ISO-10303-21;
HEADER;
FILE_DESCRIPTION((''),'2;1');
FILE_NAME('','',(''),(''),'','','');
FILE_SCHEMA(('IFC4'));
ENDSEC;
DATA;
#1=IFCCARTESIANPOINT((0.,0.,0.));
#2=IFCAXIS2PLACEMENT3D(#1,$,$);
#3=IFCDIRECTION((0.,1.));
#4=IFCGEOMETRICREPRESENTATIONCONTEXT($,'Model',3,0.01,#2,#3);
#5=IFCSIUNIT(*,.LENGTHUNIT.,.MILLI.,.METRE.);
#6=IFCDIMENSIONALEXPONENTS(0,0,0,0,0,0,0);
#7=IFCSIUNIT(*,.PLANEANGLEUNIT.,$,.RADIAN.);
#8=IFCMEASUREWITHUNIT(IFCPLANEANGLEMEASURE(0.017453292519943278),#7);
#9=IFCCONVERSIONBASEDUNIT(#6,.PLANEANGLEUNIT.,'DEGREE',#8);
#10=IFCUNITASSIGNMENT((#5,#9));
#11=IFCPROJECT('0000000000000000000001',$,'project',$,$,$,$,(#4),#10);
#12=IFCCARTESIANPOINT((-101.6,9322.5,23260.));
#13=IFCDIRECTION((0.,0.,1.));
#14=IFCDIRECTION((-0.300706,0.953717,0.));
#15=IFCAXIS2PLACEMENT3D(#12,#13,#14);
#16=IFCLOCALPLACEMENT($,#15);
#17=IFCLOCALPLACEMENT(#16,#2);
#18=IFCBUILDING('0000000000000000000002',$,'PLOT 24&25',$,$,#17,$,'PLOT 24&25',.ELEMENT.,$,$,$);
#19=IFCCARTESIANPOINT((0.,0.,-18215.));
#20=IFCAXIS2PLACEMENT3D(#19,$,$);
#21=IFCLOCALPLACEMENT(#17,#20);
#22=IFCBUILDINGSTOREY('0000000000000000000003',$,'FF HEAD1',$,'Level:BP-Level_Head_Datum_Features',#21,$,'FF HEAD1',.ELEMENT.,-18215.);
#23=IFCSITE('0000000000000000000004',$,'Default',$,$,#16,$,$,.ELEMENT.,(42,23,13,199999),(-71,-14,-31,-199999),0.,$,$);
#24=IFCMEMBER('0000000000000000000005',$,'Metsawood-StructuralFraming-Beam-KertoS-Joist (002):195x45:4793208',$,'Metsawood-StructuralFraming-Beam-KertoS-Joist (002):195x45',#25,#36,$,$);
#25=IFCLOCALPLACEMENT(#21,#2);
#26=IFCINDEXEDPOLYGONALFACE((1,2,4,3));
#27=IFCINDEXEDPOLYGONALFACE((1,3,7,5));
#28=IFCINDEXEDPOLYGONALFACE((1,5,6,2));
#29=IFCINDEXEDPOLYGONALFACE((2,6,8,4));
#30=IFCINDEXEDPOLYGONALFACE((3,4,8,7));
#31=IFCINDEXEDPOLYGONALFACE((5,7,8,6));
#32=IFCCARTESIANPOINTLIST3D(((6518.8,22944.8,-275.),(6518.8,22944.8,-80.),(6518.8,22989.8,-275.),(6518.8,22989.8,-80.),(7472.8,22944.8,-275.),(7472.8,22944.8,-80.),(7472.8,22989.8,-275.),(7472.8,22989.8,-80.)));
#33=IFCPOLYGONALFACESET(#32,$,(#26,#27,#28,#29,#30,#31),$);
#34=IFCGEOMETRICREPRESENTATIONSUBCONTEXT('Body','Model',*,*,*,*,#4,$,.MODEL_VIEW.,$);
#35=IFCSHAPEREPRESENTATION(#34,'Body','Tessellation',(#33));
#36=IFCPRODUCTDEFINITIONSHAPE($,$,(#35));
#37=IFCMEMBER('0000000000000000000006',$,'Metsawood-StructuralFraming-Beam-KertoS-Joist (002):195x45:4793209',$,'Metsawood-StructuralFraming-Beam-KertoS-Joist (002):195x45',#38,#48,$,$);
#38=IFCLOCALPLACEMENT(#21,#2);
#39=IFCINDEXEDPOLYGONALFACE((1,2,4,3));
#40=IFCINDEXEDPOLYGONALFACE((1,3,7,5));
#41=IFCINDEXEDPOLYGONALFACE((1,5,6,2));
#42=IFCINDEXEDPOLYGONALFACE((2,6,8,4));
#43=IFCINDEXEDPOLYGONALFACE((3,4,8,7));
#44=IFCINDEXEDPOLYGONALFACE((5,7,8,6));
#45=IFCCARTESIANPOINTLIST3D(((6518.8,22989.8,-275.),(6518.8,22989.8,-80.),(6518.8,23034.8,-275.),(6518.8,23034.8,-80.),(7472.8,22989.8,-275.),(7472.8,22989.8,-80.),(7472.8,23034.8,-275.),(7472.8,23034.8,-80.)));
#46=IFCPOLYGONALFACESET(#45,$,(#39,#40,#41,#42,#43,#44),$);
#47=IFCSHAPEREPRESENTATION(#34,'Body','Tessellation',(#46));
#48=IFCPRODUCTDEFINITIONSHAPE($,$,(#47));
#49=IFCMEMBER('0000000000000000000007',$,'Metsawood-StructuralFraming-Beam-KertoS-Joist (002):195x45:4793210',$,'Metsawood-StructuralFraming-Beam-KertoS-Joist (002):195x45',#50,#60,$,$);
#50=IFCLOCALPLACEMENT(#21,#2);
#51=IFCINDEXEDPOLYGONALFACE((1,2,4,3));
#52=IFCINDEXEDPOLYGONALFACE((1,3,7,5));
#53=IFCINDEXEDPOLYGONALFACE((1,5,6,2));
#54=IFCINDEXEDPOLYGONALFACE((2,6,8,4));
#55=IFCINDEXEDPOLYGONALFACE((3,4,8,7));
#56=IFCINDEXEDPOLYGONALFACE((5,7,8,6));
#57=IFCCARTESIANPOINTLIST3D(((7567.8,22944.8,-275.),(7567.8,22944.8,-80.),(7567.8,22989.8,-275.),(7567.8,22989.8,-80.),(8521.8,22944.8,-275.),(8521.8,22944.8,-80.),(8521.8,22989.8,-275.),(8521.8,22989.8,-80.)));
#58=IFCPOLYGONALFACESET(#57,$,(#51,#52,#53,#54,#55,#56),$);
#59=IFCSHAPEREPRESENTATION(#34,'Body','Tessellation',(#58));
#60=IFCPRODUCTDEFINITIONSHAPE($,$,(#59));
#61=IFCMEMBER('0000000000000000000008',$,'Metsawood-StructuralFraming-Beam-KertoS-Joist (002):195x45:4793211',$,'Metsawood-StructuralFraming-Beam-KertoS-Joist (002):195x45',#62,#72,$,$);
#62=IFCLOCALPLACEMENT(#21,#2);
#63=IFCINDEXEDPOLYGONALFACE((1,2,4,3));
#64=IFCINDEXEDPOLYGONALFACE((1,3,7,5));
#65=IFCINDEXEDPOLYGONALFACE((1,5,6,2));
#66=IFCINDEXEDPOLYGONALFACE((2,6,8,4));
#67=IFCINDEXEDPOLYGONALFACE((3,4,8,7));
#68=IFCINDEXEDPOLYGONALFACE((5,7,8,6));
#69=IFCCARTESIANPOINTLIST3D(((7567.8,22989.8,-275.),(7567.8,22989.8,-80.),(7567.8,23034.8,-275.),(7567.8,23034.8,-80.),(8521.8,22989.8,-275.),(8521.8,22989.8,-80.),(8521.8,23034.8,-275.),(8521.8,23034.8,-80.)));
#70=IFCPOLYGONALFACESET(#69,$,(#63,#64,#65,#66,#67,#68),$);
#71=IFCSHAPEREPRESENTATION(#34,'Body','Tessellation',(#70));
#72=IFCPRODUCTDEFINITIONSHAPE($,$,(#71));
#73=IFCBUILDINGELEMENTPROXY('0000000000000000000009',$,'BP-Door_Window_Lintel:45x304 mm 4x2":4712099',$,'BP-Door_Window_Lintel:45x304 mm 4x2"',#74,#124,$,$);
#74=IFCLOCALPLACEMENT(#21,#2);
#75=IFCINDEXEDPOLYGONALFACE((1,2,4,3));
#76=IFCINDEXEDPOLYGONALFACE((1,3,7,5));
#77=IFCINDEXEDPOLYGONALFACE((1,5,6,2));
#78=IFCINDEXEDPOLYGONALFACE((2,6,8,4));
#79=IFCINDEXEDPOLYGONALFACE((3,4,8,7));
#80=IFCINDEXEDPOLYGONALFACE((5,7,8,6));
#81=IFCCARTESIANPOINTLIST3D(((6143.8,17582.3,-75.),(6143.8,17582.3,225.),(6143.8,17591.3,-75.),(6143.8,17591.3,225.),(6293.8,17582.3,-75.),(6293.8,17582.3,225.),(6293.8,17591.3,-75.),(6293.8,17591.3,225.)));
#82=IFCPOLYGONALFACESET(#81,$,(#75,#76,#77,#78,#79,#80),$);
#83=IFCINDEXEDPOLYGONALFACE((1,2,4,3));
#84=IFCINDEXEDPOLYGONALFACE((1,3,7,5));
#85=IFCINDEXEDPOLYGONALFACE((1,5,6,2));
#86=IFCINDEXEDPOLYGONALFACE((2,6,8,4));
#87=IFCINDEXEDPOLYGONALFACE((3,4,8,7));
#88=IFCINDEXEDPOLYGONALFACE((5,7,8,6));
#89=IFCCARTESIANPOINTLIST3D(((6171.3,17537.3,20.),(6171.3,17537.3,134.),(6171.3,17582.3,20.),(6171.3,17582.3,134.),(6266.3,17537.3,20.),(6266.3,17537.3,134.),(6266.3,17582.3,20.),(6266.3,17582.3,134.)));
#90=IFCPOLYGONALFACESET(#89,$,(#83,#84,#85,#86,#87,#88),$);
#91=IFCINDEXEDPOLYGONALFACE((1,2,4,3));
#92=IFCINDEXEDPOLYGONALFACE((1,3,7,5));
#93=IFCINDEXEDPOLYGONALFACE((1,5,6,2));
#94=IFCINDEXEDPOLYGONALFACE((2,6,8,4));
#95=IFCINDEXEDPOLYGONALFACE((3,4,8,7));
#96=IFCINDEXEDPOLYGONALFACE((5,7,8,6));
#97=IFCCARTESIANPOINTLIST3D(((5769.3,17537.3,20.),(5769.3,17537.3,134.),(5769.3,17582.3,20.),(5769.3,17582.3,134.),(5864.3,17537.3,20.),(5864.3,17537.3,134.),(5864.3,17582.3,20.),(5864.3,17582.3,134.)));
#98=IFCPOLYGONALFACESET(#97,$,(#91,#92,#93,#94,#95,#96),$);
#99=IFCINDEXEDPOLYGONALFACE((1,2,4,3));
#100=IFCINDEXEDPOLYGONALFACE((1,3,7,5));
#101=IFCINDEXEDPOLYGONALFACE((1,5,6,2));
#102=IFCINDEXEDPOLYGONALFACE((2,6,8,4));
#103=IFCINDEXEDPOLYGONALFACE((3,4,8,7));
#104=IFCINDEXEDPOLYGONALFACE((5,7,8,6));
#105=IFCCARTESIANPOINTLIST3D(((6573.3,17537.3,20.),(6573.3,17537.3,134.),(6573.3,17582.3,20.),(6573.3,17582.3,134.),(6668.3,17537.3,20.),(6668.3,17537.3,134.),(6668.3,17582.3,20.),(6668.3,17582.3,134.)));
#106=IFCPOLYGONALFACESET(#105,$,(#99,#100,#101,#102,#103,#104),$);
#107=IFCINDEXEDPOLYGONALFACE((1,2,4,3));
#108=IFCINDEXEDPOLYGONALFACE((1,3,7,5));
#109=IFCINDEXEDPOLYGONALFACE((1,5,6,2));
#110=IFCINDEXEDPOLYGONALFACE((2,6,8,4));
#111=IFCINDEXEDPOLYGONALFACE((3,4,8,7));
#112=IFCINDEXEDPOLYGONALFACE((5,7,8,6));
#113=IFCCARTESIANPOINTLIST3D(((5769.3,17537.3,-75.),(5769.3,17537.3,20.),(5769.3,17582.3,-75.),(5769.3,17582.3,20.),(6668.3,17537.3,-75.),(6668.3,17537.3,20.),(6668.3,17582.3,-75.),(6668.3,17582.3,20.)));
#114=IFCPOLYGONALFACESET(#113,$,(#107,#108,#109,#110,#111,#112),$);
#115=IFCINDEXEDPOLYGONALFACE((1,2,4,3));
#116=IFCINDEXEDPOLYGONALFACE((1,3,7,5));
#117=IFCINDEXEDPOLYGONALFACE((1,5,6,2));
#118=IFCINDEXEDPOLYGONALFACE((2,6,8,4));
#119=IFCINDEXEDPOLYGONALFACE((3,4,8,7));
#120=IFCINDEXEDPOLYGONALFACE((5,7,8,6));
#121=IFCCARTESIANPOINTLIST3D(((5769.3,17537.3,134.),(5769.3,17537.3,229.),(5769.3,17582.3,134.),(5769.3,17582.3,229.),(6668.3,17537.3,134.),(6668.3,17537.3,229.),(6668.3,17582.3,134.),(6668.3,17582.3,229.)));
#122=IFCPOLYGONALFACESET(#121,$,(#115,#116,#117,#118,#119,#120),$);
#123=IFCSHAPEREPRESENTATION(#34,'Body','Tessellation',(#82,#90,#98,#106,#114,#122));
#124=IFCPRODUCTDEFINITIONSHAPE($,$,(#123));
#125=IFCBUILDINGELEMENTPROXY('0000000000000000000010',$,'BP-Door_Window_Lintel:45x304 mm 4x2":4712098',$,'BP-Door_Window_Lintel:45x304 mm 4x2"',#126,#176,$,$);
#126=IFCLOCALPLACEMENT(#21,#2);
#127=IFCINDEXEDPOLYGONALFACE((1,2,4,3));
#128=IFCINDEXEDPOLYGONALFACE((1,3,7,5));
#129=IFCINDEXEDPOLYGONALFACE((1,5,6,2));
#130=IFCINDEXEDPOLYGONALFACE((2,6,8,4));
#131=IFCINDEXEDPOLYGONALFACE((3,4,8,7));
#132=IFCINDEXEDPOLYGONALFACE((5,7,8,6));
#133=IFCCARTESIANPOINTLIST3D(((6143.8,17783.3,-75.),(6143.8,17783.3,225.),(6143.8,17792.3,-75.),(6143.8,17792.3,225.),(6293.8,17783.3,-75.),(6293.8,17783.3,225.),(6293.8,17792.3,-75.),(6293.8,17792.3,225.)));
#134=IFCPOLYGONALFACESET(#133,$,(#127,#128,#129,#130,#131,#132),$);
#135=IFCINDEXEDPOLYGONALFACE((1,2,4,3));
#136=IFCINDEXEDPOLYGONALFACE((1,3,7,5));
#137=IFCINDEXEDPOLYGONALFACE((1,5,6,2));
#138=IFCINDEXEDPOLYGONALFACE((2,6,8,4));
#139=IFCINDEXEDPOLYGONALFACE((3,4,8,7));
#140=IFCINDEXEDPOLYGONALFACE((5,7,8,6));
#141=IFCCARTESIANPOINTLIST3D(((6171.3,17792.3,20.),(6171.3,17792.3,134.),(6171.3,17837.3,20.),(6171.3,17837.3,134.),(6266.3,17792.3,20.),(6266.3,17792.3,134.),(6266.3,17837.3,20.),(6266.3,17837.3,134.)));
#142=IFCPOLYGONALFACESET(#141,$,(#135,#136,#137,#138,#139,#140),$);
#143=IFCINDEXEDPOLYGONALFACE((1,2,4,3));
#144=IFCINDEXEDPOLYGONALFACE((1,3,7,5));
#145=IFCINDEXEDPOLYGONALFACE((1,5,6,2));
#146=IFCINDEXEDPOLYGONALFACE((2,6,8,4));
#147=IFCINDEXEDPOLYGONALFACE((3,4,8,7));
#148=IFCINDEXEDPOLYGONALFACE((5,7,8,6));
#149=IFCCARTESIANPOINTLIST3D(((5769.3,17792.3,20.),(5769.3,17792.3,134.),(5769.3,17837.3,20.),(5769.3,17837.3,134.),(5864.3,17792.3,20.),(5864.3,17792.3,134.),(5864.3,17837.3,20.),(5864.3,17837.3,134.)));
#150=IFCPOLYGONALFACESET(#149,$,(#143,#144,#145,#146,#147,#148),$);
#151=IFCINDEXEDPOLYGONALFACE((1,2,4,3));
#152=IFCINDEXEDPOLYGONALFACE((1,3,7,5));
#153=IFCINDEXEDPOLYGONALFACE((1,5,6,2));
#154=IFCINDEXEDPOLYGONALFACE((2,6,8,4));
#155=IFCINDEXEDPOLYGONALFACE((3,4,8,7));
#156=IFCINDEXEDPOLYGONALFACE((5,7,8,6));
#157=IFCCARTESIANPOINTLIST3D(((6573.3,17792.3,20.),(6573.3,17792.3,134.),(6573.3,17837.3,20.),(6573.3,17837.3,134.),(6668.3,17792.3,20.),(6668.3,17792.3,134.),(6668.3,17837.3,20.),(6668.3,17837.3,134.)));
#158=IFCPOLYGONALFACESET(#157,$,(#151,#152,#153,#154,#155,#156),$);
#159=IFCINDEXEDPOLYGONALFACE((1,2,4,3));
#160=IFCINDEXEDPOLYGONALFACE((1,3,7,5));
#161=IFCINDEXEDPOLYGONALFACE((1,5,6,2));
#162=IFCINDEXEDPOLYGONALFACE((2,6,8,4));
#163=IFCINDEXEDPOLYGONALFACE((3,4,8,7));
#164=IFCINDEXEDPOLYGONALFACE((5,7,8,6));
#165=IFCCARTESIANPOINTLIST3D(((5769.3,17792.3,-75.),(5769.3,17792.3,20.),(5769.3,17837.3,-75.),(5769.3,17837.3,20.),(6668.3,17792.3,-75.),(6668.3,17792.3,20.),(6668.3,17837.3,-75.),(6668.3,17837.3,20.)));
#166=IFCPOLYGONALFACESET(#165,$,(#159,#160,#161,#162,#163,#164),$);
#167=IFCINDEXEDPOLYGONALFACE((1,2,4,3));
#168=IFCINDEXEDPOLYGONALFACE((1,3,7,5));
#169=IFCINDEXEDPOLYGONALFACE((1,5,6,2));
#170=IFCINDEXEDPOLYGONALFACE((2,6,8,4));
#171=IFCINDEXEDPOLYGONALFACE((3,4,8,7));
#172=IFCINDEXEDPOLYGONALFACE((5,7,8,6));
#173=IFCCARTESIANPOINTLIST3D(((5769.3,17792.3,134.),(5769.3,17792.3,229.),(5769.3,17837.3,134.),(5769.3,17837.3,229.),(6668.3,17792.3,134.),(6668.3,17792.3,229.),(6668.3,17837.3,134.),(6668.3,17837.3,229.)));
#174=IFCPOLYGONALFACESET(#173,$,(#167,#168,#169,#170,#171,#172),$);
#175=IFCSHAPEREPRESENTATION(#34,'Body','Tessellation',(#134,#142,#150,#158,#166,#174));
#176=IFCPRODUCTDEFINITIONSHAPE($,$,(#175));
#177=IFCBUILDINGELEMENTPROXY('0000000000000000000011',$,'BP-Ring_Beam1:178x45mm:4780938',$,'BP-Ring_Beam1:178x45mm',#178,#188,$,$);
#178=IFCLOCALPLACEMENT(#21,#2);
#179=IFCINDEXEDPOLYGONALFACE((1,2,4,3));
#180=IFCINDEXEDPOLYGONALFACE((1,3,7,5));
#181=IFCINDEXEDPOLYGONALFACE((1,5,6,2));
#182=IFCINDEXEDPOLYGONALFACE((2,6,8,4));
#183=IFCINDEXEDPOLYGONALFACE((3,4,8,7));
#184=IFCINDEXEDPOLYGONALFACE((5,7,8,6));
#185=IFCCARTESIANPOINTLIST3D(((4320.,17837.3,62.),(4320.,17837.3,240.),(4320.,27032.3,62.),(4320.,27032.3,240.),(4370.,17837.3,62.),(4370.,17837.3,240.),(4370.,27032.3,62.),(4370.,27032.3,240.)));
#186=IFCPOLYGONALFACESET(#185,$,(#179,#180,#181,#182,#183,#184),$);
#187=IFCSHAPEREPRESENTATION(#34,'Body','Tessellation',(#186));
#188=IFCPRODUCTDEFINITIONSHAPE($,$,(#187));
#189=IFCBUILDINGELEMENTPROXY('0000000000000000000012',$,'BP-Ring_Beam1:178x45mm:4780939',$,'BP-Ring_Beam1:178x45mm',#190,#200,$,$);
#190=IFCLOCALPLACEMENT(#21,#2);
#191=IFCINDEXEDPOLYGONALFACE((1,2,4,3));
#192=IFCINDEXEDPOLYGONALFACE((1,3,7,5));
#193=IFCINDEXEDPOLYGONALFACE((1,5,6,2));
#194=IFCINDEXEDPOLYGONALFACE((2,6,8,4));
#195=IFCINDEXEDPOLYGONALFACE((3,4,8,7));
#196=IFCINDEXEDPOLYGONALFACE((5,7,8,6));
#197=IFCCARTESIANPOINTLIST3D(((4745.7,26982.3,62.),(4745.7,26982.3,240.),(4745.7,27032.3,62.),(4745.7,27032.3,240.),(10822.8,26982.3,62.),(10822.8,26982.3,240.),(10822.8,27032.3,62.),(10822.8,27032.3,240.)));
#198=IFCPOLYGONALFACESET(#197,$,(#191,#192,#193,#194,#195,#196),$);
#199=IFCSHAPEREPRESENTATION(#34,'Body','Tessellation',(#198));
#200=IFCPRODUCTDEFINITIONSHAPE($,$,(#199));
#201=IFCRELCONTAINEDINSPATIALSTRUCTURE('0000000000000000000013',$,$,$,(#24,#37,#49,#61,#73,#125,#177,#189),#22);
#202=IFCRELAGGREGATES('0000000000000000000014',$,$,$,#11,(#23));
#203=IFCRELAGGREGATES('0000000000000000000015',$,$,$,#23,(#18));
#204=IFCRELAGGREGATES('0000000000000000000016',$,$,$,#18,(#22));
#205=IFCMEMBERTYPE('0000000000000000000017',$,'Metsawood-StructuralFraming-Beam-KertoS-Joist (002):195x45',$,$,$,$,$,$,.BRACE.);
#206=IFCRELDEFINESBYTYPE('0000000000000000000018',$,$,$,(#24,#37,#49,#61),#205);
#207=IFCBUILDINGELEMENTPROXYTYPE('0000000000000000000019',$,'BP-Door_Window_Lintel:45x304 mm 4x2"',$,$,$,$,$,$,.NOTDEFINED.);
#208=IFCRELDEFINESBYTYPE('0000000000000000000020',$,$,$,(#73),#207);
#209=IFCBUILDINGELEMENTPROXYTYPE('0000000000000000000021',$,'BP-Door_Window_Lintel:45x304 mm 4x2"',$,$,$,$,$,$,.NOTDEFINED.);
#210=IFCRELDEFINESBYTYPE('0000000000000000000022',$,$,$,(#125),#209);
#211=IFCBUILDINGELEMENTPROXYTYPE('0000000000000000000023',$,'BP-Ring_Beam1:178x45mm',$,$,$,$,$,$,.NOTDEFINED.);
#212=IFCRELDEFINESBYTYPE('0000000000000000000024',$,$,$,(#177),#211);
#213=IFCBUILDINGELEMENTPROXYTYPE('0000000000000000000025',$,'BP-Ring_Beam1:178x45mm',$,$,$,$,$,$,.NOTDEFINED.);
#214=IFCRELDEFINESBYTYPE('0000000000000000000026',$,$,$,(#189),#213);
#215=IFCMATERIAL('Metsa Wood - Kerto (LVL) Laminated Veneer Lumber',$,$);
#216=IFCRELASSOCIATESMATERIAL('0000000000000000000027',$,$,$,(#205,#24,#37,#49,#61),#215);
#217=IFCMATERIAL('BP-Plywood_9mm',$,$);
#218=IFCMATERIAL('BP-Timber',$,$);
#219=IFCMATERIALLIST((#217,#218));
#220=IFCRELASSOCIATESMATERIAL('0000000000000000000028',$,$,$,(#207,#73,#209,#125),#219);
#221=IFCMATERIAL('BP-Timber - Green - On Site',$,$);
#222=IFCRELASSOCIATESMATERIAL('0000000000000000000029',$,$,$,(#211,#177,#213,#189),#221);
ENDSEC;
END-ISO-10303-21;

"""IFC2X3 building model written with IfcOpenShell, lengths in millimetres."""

from ifc_helpers import new_model, entity, si_unit, converted_unit, direction, frame, frame_2d, origin, origin_2d_with_axis, place, context, subcontext, project, spatial, rectangle, extrude, source, transform, mapped, material, material_list, type_object, type_shapes, element, save


model = new_model("IFC2X3")

# Units and contexts
model_context = context("Model", 3, precision=0.01, world=origin(), true_north=direction((0.0, 1.0)))
body_context = subcontext(model_context, "Body", "Model", "MODEL_VIEW")
ifc_project = project(units=[si_unit("LENGTHUNIT", "METRE", prefix="MILLI"), converted_unit("PLANEANGLEUNIT", "DEGREE", entity("IfcPlaneAngleMeasure", 0.017453292519943278), si_unit("PLANEANGLEUNIT", "RADIAN"), dimensions=[0, 0, 0, 0, 0, 0, 0])], contexts=[model_context])

# Site, building, storey
site_placement = place(None, frame((-101.6, 9322.5, 23260.0), z_axis=(0.0, 0.0, 1.0), x_axis=(-0.300706, 0.953717, 0.0)))
site = spatial("IfcSite", under=ifc_project, at=site_placement, Name="Default", CompositionType="ELEMENT", RefLatitude=(42, 23, 13, 199999), RefLongitude=(-71, -14, -31, -199999), RefElevation=0.0)
building_placement = place(site_placement, origin())
building = spatial("IfcBuilding", under=site, at=building_placement, Name="PLOT 24&25", LongName="PLOT 24&25", CompositionType="ELEMENT")
storey_placement = place(building_placement, frame((0.0, 0.0, -18215.0)))
storey = spatial("IfcBuildingStorey", under=building, at=storey_placement, Name="FF HEAD1", ObjectType="Level:BP-Level_Head_Datum_Features", LongName="FF HEAD1", CompositionType="ELEMENT", Elevation=-18215.0)

# Members
ifc_material_1 = material(Name="Metsa Wood - Kerto (LVL) Laminated Veneer Lumber")
member_type = type_object("IfcMemberType", Name="Metsawood-StructuralFraming-Beam-KertoS-Joist (002):195x45", PredefinedType="BRACE", material=ifc_material_1)
shared_shape_1 = source(origin(), body_context, "Body", "SweptSolid", [
    extrude(rectangle(XDim=195.0, YDim=45.0, at=frame_2d((0.0, 0.0), x_axis=(1.0, 0.0))), frame((-477.0, 0.0, 0.0), z_axis=(1.0, 0.0, 0.0), x_axis=(0.0, 0.0, -1.0)), (0.0, 0.0, 1.0), 954.0),
])
type_shapes(member_type, [shared_shape_1])
for number, where, z_axis, x_axis, name in (
    (1, (6995.8, 22967.3, -177.5), (0.0, 0.0, 1.0), (-1.0, 0.0, 0.0), "Metsawood-StructuralFraming-Beam-KertoS-Joist (002):195x45:4793208"),
    (2, (6995.8, 23012.3, -177.5), (0.0, 0.0, 1.0), (-1.0, 0.0, 0.0), "Metsawood-StructuralFraming-Beam-KertoS-Joist (002):195x45:4793209"),
    (3, (8044.8, 22967.3, -177.5), (0.0, 0.0, 1.0), (-1.0, 0.0, 0.0), "Metsawood-StructuralFraming-Beam-KertoS-Joist (002):195x45:4793210"),
    (4, (8044.8, 23012.3, -177.5), (0.0, 0.0, 1.0), (-1.0, 0.0, 0.0), "Metsawood-StructuralFraming-Beam-KertoS-Joist (002):195x45:4793211"),
):
    element("IfcMember", number, at=place(storey_placement, frame(where, z_axis=z_axis, x_axis=x_axis)), inside=storey, type_object=member_type, material=ifc_material_1, Name=name, ObjectType="Metsawood-StructuralFraming-Beam-KertoS-Joist (002):195x45", context=body_context, shape_type="MappedRepresentation", body=[
        mapped(shared_shape_1, transform((0.0, 0.0, 0.0), scale=1.0)),
    ])

# Building element proxies
ifc_material_2 = material(Name="BP-Plywood_9mm")
ifc_material_3 = material(Name="BP-Timber")
ifc_material_list_1 = material_list([ifc_material_2, ifc_material_3])
building_element_proxy_type_1 = type_object("IfcBuildingElementProxyType", Name="BP-Door_Window_Lintel:45x304 mm 4x2\"", PredefinedType="NOTDEFINED", material=ifc_material_list_1)
shared_shape_2 = source(origin(), body_context, "Body", "SweptSolid", [
    extrude(rectangle(XDim=150.0, YDim=9.0, at=origin_2d_with_axis()), frame((746.4, -27.0, 0.0), z_axis=(0.0, 0.0, 1.0), x_axis=(-1.0, 0.0, 0.0)), (0.0, 0.0, 1.0), 300.0),
    extrude(rectangle(XDim=95.0, YDim=45.0, at=origin_2d_with_axis()), frame((746.4, 0.0, 95.0), z_axis=(0.0, 0.0, 1.0), x_axis=(-1.0, 0.0, 0.0)), (0.0, 0.0, 1.0), 114.0),
    extrude(rectangle(XDim=45.0, YDim=95.0, at=origin_2d_with_axis()), frame((1148.4, 0.0, 95.0), z_axis=(0.0, 0.0, 1.0), x_axis=(0.0, -1.0, 0.0)), (0.0, 0.0, 1.0), 114.0),
    extrude(rectangle(XDim=95.0, YDim=45.0, at=frame_2d((0.0, 0.0), x_axis=(1.0, 0.0))), frame((344.4, 0.0, 95.0), z_axis=(0.0, 0.0, 1.0), x_axis=(-1.0, 0.0, 0.0)), (0.0, 0.0, 1.0), 114.0),
    extrude(rectangle(XDim=899.0, YDim=45.0, at=frame_2d((0.0, 0.0), x_axis=(1.0, 0.0))), frame((746.4, 0.0, 0.0)), (0.0, 0.0, 1.0), 95.0),
    extrude(rectangle(XDim=899.0, YDim=45.0, at=frame_2d((0.0, 0.0), x_axis=(1.0, 0.0))), frame((746.4, 0.0, 209.0)), (0.0, 0.0, 1.0), 95.0),
])
type_shapes(building_element_proxy_type_1, [shared_shape_2])
proxy_1_placement = place(storey_placement, frame((6965.2, 17559.8, -75.0), z_axis=(0.0, 0.0, 1.0), x_axis=(-1.0, 0.0, 0.0)))
element("IfcBuildingElementProxy", 5, at=proxy_1_placement, inside=storey, type_object=building_element_proxy_type_1, material=ifc_material_list_1, Name="BP-Door_Window_Lintel:45x304 mm 4x2\":4712099", ObjectType="BP-Door_Window_Lintel:45x304 mm 4x2\"", context=body_context, shape_type="MappedRepresentation", body=[
    mapped(shared_shape_2, transform((0.0, 0.0, 0.0), scale=1.0)),
])
building_element_proxy_type_2 = type_object("IfcBuildingElementProxyType", Name="BP-Door_Window_Lintel:45x304 mm 4x2\"", PredefinedType="NOTDEFINED", material=ifc_material_list_1)
shared_shape_3 = source(origin(), body_context, "Body", "SweptSolid", [
    extrude(rectangle(XDim=9.0, YDim=150.0, at=origin_2d_with_axis()), frame((746.4, 27.0, 0.0), z_axis=(0.0, 0.0, 1.0), x_axis=(0.0, 1.0, 0.0)), (0.0, 0.0, 1.0), 300.0),
    extrude(rectangle(XDim=45.0, YDim=95.0, at=origin_2d_with_axis()), frame((746.4, 0.0, 95.0), z_axis=(0.0, 0.0, 1.0), x_axis=(0.0, 1.0, 0.0)), (0.0, 0.0, 1.0), 114.0),
    extrude(rectangle(XDim=95.0, YDim=45.0, at=origin_2d_with_axis()), frame((1148.4, 0.0, 95.0)), (0.0, 0.0, 1.0), 114.0),
    extrude(rectangle(XDim=45.0, YDim=95.0, at=frame_2d((0.0, 0.0), x_axis=(1.0, 0.0))), frame((344.4, 0.0, 95.0), z_axis=(0.0, 0.0, 1.0), x_axis=(0.0, 1.0, 0.0)), (0.0, 0.0, 1.0), 114.0),
    extrude(rectangle(XDim=45.0, YDim=899.0, at=origin_2d_with_axis()), frame((746.4, 0.0, 0.0), z_axis=(0.0, 0.0, 1.0), x_axis=(0.0, -1.0, 0.0)), (0.0, 0.0, 1.0), 95.0),
    extrude(rectangle(XDim=45.0, YDim=899.0, at=origin_2d_with_axis()), frame((746.4, 0.0, 209.0), z_axis=(0.0, 0.0, 1.0), x_axis=(0.0, -1.0, 0.0)), (0.0, 0.0, 1.0), 95.0),
])
type_shapes(building_element_proxy_type_2, [shared_shape_3])
proxy_2_placement = place(storey_placement, frame((6965.2, 17814.8, -75.0), z_axis=(0.0, 0.0, 1.0), x_axis=(-1.0, 0.0, 0.0)))
element("IfcBuildingElementProxy", 6, at=proxy_2_placement, inside=storey, type_object=building_element_proxy_type_2, material=ifc_material_list_1, Name="BP-Door_Window_Lintel:45x304 mm 4x2\":4712098", ObjectType="BP-Door_Window_Lintel:45x304 mm 4x2\"", context=body_context, shape_type="MappedRepresentation", body=[
    mapped(shared_shape_3, transform((0.0, 0.0, 0.0), scale=1.0)),
])
ifc_material_4 = material(Name="BP-Timber - Green - On Site")
building_element_proxy_type_3 = type_object("IfcBuildingElementProxyType", Name="BP-Ring_Beam1:178x45mm", PredefinedType="NOTDEFINED", material=ifc_material_4)
shared_shape_4 = source(origin(), body_context, "Body", "SweptSolid", [
    extrude(rectangle(XDim=9195.0, YDim=50.0, at=origin_2d_with_axis()), frame((0.0, -25.0, -178.0), z_axis=(0.0, 0.0, 1.0), x_axis=(-1.0, 0.0, 0.0)), (0.0, 0.0, 1.0), 178.0),
])
type_shapes(building_element_proxy_type_3, [shared_shape_4])
proxy_3_placement = place(storey_placement, frame((4370.0, 22434.8, 240.0), z_axis=(0.0, 0.0, 1.0), x_axis=(0.0, -1.0, 0.0)))
element("IfcBuildingElementProxy", 7, at=proxy_3_placement, inside=storey, type_object=building_element_proxy_type_3, material=ifc_material_4, Name="BP-Ring_Beam1:178x45mm:4780938", ObjectType="BP-Ring_Beam1:178x45mm", context=body_context, shape_type="MappedRepresentation", body=[
    mapped(shared_shape_4, transform((0.0, 0.0, 0.0), scale=1.0)),
])
building_element_proxy_type_4 = type_object("IfcBuildingElementProxyType", Name="BP-Ring_Beam1:178x45mm", PredefinedType="NOTDEFINED", material=ifc_material_4)
shared_shape_5 = source(origin(), body_context, "Body", "SweptSolid", [
    extrude(rectangle(XDim=50.0, YDim=6077.2, at=origin_2d_with_axis()), frame((0.0, 25.0, -178.0), z_axis=(0.0, 0.0, 1.0), x_axis=(0.0, 1.0, 0.0)), (0.0, 0.0, 1.0), 178.0),
])
type_shapes(building_element_proxy_type_4, [shared_shape_5])
for number, where, z_axis, x_axis, name in (
    (8, (7784.3, 27032.3, 240.0), (0.0, 0.0, 1.0), (-1.0, 0.0, 0.0), "BP-Ring_Beam1:178x45mm:4780939"),
):
    element("IfcBuildingElementProxy", number, at=place(storey_placement, frame(where, z_axis=z_axis, x_axis=x_axis)), inside=storey, type_object=building_element_proxy_type_4, material=ifc_material_4, Name=name, ObjectType="BP-Ring_Beam1:178x45mm", context=body_context, shape_type="MappedRepresentation", body=[
        mapped(shared_shape_5, transform((0.0, 0.0, 0.0), scale=1.0)),
    ])

save(model, "model.ifc")
